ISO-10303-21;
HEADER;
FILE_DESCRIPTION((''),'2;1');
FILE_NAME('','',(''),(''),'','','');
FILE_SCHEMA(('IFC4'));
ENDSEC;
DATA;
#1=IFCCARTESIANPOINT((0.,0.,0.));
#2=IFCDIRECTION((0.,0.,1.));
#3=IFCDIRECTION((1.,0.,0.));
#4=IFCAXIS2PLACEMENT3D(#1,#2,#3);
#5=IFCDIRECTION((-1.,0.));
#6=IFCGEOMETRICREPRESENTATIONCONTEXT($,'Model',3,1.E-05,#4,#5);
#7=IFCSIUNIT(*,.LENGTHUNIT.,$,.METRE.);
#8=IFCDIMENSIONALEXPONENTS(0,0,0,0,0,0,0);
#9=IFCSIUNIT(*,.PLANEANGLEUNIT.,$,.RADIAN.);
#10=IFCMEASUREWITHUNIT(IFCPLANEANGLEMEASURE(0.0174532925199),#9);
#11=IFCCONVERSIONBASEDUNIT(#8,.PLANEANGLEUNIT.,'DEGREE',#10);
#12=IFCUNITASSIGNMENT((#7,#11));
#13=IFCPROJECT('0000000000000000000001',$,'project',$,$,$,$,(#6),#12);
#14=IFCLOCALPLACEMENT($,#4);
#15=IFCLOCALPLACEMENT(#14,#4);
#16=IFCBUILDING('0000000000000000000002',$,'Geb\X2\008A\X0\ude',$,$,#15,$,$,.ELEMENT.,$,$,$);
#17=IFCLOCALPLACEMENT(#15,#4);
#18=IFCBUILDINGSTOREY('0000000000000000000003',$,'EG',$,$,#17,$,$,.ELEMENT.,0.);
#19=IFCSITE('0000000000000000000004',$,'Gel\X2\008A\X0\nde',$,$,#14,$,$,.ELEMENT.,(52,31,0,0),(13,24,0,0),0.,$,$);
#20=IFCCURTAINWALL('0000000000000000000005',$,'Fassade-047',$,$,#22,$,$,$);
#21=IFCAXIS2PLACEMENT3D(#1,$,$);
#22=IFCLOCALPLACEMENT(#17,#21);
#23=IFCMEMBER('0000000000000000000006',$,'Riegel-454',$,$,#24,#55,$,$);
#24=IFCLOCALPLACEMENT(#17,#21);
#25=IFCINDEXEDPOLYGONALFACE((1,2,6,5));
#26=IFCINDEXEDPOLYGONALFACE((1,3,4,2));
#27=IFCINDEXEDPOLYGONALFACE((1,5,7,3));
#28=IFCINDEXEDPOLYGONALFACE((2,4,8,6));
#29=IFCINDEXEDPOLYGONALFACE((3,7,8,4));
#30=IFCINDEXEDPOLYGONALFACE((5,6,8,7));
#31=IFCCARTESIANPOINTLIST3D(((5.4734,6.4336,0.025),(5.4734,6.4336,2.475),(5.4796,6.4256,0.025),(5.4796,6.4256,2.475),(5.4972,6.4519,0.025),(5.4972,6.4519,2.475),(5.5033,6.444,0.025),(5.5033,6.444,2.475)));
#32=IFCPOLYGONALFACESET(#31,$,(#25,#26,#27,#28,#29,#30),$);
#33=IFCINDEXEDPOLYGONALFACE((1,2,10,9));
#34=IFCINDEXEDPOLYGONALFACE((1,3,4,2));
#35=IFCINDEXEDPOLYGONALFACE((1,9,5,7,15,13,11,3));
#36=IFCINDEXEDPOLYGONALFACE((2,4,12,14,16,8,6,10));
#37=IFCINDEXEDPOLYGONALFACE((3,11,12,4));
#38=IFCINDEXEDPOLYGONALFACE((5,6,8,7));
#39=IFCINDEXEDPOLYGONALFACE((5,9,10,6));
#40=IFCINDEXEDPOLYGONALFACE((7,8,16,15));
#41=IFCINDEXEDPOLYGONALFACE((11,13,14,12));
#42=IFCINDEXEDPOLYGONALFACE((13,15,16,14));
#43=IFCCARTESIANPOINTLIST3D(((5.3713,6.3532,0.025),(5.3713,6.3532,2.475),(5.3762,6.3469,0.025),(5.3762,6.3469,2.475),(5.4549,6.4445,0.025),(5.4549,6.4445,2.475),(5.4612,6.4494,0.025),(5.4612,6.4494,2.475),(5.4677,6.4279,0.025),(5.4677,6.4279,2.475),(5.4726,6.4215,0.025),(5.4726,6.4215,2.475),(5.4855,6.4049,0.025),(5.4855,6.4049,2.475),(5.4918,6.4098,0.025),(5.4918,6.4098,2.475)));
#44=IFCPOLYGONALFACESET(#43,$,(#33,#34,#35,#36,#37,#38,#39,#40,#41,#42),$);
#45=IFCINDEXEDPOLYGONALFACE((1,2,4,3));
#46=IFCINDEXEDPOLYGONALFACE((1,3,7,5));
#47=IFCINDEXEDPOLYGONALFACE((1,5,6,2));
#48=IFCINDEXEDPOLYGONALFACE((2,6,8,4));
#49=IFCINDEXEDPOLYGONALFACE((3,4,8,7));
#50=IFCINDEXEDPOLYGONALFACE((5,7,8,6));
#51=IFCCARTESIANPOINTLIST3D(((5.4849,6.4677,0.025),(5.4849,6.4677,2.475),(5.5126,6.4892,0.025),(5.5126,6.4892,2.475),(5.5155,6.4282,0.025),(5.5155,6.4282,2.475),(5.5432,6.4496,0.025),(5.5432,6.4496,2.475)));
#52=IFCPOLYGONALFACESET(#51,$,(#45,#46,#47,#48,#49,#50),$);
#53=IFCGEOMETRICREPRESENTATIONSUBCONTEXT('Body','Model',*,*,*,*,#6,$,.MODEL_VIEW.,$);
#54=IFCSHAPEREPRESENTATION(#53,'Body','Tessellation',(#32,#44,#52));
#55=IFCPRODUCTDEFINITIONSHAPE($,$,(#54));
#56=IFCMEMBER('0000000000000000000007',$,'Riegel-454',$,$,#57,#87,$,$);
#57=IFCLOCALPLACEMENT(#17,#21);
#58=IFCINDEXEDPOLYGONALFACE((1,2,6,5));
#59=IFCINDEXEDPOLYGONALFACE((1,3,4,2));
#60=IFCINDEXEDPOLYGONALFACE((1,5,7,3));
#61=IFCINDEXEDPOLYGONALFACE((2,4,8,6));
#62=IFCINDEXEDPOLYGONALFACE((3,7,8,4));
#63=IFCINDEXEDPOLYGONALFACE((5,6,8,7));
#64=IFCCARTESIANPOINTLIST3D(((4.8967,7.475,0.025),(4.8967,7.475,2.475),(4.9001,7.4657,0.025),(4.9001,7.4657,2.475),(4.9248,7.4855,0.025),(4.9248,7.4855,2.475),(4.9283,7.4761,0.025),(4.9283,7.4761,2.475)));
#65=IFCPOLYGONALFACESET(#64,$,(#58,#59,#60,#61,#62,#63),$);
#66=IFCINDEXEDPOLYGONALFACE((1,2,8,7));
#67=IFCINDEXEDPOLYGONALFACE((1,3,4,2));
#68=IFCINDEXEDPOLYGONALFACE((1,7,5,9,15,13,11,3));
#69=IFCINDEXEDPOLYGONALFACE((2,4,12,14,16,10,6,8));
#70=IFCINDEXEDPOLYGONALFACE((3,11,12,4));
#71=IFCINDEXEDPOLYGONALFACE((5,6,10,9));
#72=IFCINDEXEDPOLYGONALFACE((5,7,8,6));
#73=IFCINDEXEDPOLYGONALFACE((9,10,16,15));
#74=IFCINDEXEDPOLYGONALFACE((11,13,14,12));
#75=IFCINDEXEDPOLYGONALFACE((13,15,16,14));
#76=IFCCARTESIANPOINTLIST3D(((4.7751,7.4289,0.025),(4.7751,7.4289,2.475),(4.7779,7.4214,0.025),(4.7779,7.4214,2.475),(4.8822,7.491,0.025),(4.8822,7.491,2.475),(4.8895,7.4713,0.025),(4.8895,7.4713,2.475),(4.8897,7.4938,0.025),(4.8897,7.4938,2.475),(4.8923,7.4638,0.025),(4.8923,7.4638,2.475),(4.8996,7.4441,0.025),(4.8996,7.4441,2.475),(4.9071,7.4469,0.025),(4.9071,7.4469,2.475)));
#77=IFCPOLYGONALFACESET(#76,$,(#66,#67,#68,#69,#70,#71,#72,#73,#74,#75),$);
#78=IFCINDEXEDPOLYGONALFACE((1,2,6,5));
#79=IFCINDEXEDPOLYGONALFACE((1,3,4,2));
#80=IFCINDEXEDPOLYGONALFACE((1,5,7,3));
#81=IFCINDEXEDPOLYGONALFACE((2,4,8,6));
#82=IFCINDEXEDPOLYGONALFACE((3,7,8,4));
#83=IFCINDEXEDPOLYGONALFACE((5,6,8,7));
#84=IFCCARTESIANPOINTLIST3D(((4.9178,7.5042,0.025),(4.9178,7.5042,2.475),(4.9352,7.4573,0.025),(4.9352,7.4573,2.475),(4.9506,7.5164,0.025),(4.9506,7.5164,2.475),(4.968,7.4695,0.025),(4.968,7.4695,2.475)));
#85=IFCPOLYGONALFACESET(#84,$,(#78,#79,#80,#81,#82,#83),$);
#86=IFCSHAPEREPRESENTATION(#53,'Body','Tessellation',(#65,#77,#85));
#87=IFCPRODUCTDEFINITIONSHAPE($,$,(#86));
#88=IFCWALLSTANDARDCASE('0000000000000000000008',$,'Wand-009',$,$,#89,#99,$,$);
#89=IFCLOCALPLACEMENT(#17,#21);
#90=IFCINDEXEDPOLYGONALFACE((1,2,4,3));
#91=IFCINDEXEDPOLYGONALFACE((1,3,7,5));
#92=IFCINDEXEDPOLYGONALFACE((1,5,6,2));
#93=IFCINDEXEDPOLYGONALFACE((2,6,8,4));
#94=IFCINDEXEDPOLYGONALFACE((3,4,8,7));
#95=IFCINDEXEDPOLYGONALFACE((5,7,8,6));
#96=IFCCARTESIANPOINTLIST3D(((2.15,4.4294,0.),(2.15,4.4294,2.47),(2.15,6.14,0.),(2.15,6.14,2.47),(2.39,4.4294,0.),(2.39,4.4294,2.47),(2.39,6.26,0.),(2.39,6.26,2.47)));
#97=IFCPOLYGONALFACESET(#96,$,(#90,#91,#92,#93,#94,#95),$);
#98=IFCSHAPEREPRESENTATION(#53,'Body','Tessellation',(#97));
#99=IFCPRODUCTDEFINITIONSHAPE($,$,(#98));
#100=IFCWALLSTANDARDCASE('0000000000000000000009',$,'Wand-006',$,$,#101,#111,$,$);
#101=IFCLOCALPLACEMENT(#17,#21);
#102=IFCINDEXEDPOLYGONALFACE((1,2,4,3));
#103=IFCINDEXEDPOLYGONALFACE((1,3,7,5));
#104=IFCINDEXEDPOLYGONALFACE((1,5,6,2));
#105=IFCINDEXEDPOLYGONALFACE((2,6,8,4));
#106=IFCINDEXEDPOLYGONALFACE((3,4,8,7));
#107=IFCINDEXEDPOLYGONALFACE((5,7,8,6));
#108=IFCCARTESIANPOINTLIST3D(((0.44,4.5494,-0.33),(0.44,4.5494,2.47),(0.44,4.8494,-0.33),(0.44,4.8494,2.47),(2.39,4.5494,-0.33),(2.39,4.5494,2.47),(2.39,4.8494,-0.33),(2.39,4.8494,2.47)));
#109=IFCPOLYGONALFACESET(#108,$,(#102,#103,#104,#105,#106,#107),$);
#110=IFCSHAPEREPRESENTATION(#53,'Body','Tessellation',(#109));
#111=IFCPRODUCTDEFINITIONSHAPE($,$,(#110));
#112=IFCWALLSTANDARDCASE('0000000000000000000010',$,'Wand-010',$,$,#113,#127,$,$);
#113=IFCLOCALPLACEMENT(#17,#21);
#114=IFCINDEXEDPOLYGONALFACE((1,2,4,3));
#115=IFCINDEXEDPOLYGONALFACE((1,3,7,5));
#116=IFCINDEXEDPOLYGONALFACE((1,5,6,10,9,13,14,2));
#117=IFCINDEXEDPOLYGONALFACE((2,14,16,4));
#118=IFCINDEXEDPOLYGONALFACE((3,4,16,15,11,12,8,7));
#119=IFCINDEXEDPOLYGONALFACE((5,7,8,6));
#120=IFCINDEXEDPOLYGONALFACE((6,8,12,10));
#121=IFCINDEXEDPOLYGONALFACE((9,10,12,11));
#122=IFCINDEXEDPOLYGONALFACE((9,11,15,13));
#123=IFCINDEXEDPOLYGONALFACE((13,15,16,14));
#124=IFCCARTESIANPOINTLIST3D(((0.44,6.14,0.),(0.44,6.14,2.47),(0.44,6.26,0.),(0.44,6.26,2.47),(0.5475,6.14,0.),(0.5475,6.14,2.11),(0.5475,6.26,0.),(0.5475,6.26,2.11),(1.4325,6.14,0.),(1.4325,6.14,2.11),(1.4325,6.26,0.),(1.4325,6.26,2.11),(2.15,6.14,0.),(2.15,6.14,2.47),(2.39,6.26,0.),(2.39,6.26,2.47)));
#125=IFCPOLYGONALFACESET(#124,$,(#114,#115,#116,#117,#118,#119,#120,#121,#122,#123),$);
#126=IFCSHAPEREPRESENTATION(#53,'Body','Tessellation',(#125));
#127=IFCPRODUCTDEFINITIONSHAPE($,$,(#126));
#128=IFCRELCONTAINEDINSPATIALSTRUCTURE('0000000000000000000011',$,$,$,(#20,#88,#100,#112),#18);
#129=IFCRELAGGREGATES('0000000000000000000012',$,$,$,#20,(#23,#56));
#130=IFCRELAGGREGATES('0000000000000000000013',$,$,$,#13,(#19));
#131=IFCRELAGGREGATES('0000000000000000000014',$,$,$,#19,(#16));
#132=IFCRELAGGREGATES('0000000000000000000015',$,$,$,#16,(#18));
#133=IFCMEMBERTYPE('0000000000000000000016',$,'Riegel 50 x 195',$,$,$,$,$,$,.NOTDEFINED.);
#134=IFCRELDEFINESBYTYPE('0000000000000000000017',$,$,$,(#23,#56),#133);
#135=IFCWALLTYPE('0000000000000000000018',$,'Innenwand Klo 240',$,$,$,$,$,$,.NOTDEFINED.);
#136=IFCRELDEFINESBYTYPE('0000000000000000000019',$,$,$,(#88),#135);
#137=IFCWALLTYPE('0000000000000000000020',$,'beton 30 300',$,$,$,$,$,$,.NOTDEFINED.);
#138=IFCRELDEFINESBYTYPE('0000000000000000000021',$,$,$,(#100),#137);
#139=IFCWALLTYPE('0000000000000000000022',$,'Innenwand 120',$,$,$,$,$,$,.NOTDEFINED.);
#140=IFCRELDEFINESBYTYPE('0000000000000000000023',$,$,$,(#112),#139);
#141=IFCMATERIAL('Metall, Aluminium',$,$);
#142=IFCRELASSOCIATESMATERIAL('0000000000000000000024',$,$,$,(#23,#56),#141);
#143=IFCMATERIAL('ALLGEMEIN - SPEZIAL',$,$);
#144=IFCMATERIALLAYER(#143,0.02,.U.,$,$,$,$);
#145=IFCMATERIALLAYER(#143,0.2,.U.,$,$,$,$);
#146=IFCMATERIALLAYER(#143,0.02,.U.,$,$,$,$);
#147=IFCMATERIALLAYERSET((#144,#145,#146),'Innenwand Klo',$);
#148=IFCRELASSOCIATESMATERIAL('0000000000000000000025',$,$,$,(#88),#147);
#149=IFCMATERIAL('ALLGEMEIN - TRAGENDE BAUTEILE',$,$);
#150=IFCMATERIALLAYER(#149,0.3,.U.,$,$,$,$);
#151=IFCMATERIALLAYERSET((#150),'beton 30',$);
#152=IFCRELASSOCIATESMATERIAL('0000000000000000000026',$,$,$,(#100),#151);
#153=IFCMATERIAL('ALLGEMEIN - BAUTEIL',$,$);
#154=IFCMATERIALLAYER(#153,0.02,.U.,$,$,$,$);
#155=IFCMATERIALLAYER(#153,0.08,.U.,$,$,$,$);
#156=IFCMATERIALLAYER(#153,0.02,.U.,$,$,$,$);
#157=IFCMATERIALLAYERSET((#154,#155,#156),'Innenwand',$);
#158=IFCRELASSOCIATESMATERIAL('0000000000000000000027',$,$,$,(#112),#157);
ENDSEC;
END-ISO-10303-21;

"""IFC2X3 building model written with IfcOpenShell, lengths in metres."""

from ifc_helpers import new_model, entity, si_unit, converted_unit, direction, frame, origin_with_axes, origin_2d_with_axis, place, context, subcontext, project, spatial, polyline, rectangle, outline, extrude, material, layer, layer_set, layer_usage, type_object, element, aggregate, save


model = new_model("IFC2X3")

# Units and contexts
model_context = context("Model", 3, precision=1e-05, world=origin_with_axes(), true_north=direction((-1.0, 0.0)))
body_context = subcontext(model_context, "Body", "Model", "MODEL_VIEW")
ifc_project = project(units=[si_unit("LENGTHUNIT", "METRE"), converted_unit("PLANEANGLEUNIT", "DEGREE", entity("IfcPlaneAngleMeasure", 0.0174532925199), si_unit("PLANEANGLEUNIT", "RADIAN"), dimensions=[0, 0, 0, 0, 0, 0, 0])], contexts=[model_context])

# Site, building, storey
site_placement = place(None, origin_with_axes())
site = spatial("IfcSite", under=ifc_project, at=site_placement, Name="Gel\u008ande", CompositionType="ELEMENT", RefLatitude=(52, 31, 0, 0), RefLongitude=(13, 24, 0, 0), RefElevation=0.0)
building_placement = place(site_placement, origin_with_axes())
building = spatial("IfcBuilding", under=site, at=building_placement, Name="Geb\u008aude", CompositionType="ELEMENT")
storey_placement = place(building_placement, origin_with_axes())
storey = spatial("IfcBuildingStorey", under=building, at=storey_placement, Name="EG", CompositionType="ELEMENT", Elevation=0.0)

# Curtain wall, members
curtain_wall_placement = place(storey_placement, frame((7.6056, 12.5904, 0.0), z_axis=(0.0, 0.0, 1.0), x_axis=(1.0, 0.0, 0.0)))
curtain_wall = element("IfcCurtainWall", 1, at=curtain_wall_placement, inside=storey, Name="Fassade-047")
ifc_material_1 = material(Name="Metall, Aluminium")
member_type_1 = type_object("IfcMemberType", Name="Riegel 50 x 195", PredefinedType="NOTDEFINED")
member_1_placement = place(curtain_wall_placement, frame((-2.1172, -6.1516, 0.0), z_axis=(0.0, 0.0, 1.0), x_axis=(-0.612165, 0.79073, 0.0)))
member_1 = element("IfcMember", 2, at=member_1_placement, type_object=member_type_1, material=ifc_material_1, Name="Riegel-454", context=body_context, shape_type="SweptSolid", body=[
    extrude(outline(polyline([(-0.0149, -0.0052), (-0.0088, -0.0131), (0.0149, 0.0052), (0.0088, 0.0131), (-0.0149, -0.0052)])), frame((0.0, 0.0, 0.025), z_axis=(0.0, 0.0, 1.0), x_axis=(-0.612165, -0.79073, 0.0)), (0.0, 0.0, 1.0), 2.45),
    extrude(outline(polyline([(-0.1171, -0.0856), (-0.1122, -0.0919), (-0.0157, -0.0172), (-0.0029, -0.0338), (0.0034, -0.029), (-0.0272, 0.0106), (-0.0335, 0.0057), (-0.0206, -0.0109), (-0.1171, -0.0856)])), frame((0.0, 0.0, 0.025), z_axis=(0.0, 0.0, 1.0), x_axis=(-0.612165, -0.79073, 0.0)), (0.0, 0.0, 1.0), 2.45),
    extrude(outline(polyline([(0.0548, 0.0108), (0.0242, 0.0504), (-0.0034, 0.029), (0.0272, -0.0106), (0.0548, 0.0108)])), frame((0.0, 0.0, 0.025), z_axis=(0.0, 0.0, 1.0), x_axis=(-0.612165, -0.79073, 0.0)), (0.0, 0.0, 1.0), 2.45),
])
member_2_placement = place(curtain_wall_placement, frame((-2.6931, -5.1148, 0.0), z_axis=(0.0, 0.0, 1.0), x_axis=(-0.347847, 0.937551, 0.0)))
member_2 = element("IfcMember", 3, at=member_2_placement, type_object=member_type_1, material=ifc_material_1, Name="Riegel-454", context=body_context, shape_type="SweptSolid", body=[
    extrude(outline(polyline([(-0.0158, -0.0005), (-0.0123, -0.0099), (0.0158, 0.0005), (0.0123, 0.0099), (-0.0158, -0.0005)])), frame((0.0, 0.0, 0.025), z_axis=(0.0, 0.0, 1.0), x_axis=(-0.347847, -0.937551, 0.0)), (0.0, 0.0, 1.0), 2.45),
    extrude(outline(polyline([(-0.1373, -0.0467), (-0.1346, -0.0542), (-0.0202, -0.0118), (-0.0129, -0.0314), (-0.0054, -0.0287), (-0.0228, 0.0182), (-0.0303, 0.0154), (-0.023, -0.0043), (-0.1373, -0.0467)])), frame((0.0, 0.0, 0.025), z_axis=(0.0, 0.0, 1.0), x_axis=(-0.347847, -0.937551, 0.0)), (0.0, 0.0, 1.0), 2.45),
    extrude(outline(polyline([(0.0556, -0.006), (0.0382, 0.0408), (0.0054, 0.0287), (0.0228, -0.0182), (0.0556, -0.006)])), frame((0.0, 0.0, 0.025), z_axis=(0.0, 0.0, 1.0), x_axis=(-0.347847, -0.937551, 0.0)), (0.0, 0.0, 1.0), 2.45),
])

# Shared definitions
ifc_material_2 = material(Name="ALLGEMEIN - TRAGENDE BAUTEILE")
ifc_material_3 = material(Name="ALLGEMEIN - BAUTEIL")

aggregate(curtain_wall, [member_1, member_2])

# Walls
ifc_material_4 = material(Name="ALLGEMEIN - SPEZIAL")
ifc_layer_1 = layer(ifc_material_4, 0.02, ventilated="UNKNOWN")
ifc_layer_2 = layer(ifc_material_4, 0.2, ventilated="UNKNOWN")
ifc_layer_3 = layer(ifc_material_4, 0.02, ventilated="UNKNOWN")
ifc_layer_set_1 = layer_set([ifc_layer_1, ifc_layer_2, ifc_layer_3], Name="Innenwand Klo")
ifc_layer_usage_1 = layer_usage(ifc_layer_set_1, "AXIS2", "POSITIVE", -0.24)
wall_type_1 = type_object("IfcWallType", Name="Innenwand Klo 240", PredefinedType="NOTDEFINED")
wall_1_placement = place(storey_placement, frame((2.15, 4.4294, 0.0), z_axis=(0.0, 0.0, 1.0), x_axis=(0.0, 1.0, 0.0)))
element("IfcWallStandardCase", 4, at=wall_1_placement, inside=storey, type_object=wall_type_1, material=ifc_layer_usage_1, Name="Wand-009", context=body_context, shape_type="SweptSolid", body=[
    extrude(outline(polyline([(0.0, -0.24), (1.8306, -0.24), (1.7106, 0.0), (0.0, 0.0), (0.0, -0.24)])), origin_with_axes(), (0.0, 0.0, 1.0), 2.47),
])
ifc_layer_4 = layer(ifc_material_2, 0.3, ventilated="UNKNOWN")
ifc_layer_set_2 = layer_set([ifc_layer_4], Name="beton 30")
ifc_layer_usage_2 = layer_usage(ifc_layer_set_2, "AXIS2", "POSITIVE", -0.3)
wall_type_2 = type_object("IfcWallType", Name="beton 30 300", PredefinedType="NOTDEFINED")
wall_2_placement = place(storey_placement, frame((0.44, 4.8494, -0.33), z_axis=(0.0, 0.0, 1.0), x_axis=(1.0, 0.0, 0.0)))
element("IfcWallStandardCase", 5, at=wall_2_placement, inside=storey, type_object=wall_type_2, material=ifc_layer_usage_2, Name="Wand-006", context=body_context, shape_type="SweptSolid", body=[
    extrude(outline(polyline([(0.0, -0.3), (1.95, -0.3), (1.95, 0.0), (0.0, 0.0), (0.0, -0.3)])), origin_with_axes(), (0.0, 0.0, 1.0), 2.8),
])

# Wall, opening
ifc_layer_5 = layer(ifc_material_3, 0.02, ventilated="UNKNOWN")
ifc_layer_6 = layer(ifc_material_3, 0.08, ventilated="UNKNOWN")
ifc_layer_7 = layer(ifc_material_3, 0.02, ventilated="UNKNOWN")
ifc_layer_set_3 = layer_set([ifc_layer_5, ifc_layer_6, ifc_layer_7], Name="Innenwand")
ifc_layer_usage_3 = layer_usage(ifc_layer_set_3, "AXIS2", "POSITIVE", -0.12)
wall_type_3 = type_object("IfcWallType", Name="Innenwand 120", PredefinedType="NOTDEFINED")
wall_3_placement = place(storey_placement, frame((2.15, 6.14, 0.0), z_axis=(0.0, 0.0, 1.0), x_axis=(-1.0, 0.0, 0.0)))
wall_3 = element("IfcWallStandardCase", 6, at=wall_3_placement, inside=storey, type_object=wall_type_3, material=ifc_layer_usage_3, Name="Wand-010", context=body_context, shape_type="SweptSolid", body=[
    extrude(outline(polyline([(-0.24, -0.12), (1.71, -0.12), (1.71, 0.0), (0.0, 0.0), (-0.24, -0.12)])), origin_with_axes(), (0.0, 0.0, 1.0), 2.47),
])
opening_1_placement = place(wall_3_placement, frame((1.16, 0.0, 0.1), z_axis=(0.0, 0.0, 1.0), x_axis=(1.0, 0.0, 0.0)))
element("IfcOpeningElement", 7, at=opening_1_placement, cuts=wall_3, context=body_context, shape_type="SweptSolid", body=[
    extrude(rectangle(XDim=0.885, YDim=2.11, at=origin_2d_with_axis()), frame((0.0, 0.12, 0.955), z_axis=(0.0, -1.0, 0.0), x_axis=(1.0, 0.0, 0.0)), (0.0, 0.0, 1.0), 0.36),
])

save(model, "model.ifc")
